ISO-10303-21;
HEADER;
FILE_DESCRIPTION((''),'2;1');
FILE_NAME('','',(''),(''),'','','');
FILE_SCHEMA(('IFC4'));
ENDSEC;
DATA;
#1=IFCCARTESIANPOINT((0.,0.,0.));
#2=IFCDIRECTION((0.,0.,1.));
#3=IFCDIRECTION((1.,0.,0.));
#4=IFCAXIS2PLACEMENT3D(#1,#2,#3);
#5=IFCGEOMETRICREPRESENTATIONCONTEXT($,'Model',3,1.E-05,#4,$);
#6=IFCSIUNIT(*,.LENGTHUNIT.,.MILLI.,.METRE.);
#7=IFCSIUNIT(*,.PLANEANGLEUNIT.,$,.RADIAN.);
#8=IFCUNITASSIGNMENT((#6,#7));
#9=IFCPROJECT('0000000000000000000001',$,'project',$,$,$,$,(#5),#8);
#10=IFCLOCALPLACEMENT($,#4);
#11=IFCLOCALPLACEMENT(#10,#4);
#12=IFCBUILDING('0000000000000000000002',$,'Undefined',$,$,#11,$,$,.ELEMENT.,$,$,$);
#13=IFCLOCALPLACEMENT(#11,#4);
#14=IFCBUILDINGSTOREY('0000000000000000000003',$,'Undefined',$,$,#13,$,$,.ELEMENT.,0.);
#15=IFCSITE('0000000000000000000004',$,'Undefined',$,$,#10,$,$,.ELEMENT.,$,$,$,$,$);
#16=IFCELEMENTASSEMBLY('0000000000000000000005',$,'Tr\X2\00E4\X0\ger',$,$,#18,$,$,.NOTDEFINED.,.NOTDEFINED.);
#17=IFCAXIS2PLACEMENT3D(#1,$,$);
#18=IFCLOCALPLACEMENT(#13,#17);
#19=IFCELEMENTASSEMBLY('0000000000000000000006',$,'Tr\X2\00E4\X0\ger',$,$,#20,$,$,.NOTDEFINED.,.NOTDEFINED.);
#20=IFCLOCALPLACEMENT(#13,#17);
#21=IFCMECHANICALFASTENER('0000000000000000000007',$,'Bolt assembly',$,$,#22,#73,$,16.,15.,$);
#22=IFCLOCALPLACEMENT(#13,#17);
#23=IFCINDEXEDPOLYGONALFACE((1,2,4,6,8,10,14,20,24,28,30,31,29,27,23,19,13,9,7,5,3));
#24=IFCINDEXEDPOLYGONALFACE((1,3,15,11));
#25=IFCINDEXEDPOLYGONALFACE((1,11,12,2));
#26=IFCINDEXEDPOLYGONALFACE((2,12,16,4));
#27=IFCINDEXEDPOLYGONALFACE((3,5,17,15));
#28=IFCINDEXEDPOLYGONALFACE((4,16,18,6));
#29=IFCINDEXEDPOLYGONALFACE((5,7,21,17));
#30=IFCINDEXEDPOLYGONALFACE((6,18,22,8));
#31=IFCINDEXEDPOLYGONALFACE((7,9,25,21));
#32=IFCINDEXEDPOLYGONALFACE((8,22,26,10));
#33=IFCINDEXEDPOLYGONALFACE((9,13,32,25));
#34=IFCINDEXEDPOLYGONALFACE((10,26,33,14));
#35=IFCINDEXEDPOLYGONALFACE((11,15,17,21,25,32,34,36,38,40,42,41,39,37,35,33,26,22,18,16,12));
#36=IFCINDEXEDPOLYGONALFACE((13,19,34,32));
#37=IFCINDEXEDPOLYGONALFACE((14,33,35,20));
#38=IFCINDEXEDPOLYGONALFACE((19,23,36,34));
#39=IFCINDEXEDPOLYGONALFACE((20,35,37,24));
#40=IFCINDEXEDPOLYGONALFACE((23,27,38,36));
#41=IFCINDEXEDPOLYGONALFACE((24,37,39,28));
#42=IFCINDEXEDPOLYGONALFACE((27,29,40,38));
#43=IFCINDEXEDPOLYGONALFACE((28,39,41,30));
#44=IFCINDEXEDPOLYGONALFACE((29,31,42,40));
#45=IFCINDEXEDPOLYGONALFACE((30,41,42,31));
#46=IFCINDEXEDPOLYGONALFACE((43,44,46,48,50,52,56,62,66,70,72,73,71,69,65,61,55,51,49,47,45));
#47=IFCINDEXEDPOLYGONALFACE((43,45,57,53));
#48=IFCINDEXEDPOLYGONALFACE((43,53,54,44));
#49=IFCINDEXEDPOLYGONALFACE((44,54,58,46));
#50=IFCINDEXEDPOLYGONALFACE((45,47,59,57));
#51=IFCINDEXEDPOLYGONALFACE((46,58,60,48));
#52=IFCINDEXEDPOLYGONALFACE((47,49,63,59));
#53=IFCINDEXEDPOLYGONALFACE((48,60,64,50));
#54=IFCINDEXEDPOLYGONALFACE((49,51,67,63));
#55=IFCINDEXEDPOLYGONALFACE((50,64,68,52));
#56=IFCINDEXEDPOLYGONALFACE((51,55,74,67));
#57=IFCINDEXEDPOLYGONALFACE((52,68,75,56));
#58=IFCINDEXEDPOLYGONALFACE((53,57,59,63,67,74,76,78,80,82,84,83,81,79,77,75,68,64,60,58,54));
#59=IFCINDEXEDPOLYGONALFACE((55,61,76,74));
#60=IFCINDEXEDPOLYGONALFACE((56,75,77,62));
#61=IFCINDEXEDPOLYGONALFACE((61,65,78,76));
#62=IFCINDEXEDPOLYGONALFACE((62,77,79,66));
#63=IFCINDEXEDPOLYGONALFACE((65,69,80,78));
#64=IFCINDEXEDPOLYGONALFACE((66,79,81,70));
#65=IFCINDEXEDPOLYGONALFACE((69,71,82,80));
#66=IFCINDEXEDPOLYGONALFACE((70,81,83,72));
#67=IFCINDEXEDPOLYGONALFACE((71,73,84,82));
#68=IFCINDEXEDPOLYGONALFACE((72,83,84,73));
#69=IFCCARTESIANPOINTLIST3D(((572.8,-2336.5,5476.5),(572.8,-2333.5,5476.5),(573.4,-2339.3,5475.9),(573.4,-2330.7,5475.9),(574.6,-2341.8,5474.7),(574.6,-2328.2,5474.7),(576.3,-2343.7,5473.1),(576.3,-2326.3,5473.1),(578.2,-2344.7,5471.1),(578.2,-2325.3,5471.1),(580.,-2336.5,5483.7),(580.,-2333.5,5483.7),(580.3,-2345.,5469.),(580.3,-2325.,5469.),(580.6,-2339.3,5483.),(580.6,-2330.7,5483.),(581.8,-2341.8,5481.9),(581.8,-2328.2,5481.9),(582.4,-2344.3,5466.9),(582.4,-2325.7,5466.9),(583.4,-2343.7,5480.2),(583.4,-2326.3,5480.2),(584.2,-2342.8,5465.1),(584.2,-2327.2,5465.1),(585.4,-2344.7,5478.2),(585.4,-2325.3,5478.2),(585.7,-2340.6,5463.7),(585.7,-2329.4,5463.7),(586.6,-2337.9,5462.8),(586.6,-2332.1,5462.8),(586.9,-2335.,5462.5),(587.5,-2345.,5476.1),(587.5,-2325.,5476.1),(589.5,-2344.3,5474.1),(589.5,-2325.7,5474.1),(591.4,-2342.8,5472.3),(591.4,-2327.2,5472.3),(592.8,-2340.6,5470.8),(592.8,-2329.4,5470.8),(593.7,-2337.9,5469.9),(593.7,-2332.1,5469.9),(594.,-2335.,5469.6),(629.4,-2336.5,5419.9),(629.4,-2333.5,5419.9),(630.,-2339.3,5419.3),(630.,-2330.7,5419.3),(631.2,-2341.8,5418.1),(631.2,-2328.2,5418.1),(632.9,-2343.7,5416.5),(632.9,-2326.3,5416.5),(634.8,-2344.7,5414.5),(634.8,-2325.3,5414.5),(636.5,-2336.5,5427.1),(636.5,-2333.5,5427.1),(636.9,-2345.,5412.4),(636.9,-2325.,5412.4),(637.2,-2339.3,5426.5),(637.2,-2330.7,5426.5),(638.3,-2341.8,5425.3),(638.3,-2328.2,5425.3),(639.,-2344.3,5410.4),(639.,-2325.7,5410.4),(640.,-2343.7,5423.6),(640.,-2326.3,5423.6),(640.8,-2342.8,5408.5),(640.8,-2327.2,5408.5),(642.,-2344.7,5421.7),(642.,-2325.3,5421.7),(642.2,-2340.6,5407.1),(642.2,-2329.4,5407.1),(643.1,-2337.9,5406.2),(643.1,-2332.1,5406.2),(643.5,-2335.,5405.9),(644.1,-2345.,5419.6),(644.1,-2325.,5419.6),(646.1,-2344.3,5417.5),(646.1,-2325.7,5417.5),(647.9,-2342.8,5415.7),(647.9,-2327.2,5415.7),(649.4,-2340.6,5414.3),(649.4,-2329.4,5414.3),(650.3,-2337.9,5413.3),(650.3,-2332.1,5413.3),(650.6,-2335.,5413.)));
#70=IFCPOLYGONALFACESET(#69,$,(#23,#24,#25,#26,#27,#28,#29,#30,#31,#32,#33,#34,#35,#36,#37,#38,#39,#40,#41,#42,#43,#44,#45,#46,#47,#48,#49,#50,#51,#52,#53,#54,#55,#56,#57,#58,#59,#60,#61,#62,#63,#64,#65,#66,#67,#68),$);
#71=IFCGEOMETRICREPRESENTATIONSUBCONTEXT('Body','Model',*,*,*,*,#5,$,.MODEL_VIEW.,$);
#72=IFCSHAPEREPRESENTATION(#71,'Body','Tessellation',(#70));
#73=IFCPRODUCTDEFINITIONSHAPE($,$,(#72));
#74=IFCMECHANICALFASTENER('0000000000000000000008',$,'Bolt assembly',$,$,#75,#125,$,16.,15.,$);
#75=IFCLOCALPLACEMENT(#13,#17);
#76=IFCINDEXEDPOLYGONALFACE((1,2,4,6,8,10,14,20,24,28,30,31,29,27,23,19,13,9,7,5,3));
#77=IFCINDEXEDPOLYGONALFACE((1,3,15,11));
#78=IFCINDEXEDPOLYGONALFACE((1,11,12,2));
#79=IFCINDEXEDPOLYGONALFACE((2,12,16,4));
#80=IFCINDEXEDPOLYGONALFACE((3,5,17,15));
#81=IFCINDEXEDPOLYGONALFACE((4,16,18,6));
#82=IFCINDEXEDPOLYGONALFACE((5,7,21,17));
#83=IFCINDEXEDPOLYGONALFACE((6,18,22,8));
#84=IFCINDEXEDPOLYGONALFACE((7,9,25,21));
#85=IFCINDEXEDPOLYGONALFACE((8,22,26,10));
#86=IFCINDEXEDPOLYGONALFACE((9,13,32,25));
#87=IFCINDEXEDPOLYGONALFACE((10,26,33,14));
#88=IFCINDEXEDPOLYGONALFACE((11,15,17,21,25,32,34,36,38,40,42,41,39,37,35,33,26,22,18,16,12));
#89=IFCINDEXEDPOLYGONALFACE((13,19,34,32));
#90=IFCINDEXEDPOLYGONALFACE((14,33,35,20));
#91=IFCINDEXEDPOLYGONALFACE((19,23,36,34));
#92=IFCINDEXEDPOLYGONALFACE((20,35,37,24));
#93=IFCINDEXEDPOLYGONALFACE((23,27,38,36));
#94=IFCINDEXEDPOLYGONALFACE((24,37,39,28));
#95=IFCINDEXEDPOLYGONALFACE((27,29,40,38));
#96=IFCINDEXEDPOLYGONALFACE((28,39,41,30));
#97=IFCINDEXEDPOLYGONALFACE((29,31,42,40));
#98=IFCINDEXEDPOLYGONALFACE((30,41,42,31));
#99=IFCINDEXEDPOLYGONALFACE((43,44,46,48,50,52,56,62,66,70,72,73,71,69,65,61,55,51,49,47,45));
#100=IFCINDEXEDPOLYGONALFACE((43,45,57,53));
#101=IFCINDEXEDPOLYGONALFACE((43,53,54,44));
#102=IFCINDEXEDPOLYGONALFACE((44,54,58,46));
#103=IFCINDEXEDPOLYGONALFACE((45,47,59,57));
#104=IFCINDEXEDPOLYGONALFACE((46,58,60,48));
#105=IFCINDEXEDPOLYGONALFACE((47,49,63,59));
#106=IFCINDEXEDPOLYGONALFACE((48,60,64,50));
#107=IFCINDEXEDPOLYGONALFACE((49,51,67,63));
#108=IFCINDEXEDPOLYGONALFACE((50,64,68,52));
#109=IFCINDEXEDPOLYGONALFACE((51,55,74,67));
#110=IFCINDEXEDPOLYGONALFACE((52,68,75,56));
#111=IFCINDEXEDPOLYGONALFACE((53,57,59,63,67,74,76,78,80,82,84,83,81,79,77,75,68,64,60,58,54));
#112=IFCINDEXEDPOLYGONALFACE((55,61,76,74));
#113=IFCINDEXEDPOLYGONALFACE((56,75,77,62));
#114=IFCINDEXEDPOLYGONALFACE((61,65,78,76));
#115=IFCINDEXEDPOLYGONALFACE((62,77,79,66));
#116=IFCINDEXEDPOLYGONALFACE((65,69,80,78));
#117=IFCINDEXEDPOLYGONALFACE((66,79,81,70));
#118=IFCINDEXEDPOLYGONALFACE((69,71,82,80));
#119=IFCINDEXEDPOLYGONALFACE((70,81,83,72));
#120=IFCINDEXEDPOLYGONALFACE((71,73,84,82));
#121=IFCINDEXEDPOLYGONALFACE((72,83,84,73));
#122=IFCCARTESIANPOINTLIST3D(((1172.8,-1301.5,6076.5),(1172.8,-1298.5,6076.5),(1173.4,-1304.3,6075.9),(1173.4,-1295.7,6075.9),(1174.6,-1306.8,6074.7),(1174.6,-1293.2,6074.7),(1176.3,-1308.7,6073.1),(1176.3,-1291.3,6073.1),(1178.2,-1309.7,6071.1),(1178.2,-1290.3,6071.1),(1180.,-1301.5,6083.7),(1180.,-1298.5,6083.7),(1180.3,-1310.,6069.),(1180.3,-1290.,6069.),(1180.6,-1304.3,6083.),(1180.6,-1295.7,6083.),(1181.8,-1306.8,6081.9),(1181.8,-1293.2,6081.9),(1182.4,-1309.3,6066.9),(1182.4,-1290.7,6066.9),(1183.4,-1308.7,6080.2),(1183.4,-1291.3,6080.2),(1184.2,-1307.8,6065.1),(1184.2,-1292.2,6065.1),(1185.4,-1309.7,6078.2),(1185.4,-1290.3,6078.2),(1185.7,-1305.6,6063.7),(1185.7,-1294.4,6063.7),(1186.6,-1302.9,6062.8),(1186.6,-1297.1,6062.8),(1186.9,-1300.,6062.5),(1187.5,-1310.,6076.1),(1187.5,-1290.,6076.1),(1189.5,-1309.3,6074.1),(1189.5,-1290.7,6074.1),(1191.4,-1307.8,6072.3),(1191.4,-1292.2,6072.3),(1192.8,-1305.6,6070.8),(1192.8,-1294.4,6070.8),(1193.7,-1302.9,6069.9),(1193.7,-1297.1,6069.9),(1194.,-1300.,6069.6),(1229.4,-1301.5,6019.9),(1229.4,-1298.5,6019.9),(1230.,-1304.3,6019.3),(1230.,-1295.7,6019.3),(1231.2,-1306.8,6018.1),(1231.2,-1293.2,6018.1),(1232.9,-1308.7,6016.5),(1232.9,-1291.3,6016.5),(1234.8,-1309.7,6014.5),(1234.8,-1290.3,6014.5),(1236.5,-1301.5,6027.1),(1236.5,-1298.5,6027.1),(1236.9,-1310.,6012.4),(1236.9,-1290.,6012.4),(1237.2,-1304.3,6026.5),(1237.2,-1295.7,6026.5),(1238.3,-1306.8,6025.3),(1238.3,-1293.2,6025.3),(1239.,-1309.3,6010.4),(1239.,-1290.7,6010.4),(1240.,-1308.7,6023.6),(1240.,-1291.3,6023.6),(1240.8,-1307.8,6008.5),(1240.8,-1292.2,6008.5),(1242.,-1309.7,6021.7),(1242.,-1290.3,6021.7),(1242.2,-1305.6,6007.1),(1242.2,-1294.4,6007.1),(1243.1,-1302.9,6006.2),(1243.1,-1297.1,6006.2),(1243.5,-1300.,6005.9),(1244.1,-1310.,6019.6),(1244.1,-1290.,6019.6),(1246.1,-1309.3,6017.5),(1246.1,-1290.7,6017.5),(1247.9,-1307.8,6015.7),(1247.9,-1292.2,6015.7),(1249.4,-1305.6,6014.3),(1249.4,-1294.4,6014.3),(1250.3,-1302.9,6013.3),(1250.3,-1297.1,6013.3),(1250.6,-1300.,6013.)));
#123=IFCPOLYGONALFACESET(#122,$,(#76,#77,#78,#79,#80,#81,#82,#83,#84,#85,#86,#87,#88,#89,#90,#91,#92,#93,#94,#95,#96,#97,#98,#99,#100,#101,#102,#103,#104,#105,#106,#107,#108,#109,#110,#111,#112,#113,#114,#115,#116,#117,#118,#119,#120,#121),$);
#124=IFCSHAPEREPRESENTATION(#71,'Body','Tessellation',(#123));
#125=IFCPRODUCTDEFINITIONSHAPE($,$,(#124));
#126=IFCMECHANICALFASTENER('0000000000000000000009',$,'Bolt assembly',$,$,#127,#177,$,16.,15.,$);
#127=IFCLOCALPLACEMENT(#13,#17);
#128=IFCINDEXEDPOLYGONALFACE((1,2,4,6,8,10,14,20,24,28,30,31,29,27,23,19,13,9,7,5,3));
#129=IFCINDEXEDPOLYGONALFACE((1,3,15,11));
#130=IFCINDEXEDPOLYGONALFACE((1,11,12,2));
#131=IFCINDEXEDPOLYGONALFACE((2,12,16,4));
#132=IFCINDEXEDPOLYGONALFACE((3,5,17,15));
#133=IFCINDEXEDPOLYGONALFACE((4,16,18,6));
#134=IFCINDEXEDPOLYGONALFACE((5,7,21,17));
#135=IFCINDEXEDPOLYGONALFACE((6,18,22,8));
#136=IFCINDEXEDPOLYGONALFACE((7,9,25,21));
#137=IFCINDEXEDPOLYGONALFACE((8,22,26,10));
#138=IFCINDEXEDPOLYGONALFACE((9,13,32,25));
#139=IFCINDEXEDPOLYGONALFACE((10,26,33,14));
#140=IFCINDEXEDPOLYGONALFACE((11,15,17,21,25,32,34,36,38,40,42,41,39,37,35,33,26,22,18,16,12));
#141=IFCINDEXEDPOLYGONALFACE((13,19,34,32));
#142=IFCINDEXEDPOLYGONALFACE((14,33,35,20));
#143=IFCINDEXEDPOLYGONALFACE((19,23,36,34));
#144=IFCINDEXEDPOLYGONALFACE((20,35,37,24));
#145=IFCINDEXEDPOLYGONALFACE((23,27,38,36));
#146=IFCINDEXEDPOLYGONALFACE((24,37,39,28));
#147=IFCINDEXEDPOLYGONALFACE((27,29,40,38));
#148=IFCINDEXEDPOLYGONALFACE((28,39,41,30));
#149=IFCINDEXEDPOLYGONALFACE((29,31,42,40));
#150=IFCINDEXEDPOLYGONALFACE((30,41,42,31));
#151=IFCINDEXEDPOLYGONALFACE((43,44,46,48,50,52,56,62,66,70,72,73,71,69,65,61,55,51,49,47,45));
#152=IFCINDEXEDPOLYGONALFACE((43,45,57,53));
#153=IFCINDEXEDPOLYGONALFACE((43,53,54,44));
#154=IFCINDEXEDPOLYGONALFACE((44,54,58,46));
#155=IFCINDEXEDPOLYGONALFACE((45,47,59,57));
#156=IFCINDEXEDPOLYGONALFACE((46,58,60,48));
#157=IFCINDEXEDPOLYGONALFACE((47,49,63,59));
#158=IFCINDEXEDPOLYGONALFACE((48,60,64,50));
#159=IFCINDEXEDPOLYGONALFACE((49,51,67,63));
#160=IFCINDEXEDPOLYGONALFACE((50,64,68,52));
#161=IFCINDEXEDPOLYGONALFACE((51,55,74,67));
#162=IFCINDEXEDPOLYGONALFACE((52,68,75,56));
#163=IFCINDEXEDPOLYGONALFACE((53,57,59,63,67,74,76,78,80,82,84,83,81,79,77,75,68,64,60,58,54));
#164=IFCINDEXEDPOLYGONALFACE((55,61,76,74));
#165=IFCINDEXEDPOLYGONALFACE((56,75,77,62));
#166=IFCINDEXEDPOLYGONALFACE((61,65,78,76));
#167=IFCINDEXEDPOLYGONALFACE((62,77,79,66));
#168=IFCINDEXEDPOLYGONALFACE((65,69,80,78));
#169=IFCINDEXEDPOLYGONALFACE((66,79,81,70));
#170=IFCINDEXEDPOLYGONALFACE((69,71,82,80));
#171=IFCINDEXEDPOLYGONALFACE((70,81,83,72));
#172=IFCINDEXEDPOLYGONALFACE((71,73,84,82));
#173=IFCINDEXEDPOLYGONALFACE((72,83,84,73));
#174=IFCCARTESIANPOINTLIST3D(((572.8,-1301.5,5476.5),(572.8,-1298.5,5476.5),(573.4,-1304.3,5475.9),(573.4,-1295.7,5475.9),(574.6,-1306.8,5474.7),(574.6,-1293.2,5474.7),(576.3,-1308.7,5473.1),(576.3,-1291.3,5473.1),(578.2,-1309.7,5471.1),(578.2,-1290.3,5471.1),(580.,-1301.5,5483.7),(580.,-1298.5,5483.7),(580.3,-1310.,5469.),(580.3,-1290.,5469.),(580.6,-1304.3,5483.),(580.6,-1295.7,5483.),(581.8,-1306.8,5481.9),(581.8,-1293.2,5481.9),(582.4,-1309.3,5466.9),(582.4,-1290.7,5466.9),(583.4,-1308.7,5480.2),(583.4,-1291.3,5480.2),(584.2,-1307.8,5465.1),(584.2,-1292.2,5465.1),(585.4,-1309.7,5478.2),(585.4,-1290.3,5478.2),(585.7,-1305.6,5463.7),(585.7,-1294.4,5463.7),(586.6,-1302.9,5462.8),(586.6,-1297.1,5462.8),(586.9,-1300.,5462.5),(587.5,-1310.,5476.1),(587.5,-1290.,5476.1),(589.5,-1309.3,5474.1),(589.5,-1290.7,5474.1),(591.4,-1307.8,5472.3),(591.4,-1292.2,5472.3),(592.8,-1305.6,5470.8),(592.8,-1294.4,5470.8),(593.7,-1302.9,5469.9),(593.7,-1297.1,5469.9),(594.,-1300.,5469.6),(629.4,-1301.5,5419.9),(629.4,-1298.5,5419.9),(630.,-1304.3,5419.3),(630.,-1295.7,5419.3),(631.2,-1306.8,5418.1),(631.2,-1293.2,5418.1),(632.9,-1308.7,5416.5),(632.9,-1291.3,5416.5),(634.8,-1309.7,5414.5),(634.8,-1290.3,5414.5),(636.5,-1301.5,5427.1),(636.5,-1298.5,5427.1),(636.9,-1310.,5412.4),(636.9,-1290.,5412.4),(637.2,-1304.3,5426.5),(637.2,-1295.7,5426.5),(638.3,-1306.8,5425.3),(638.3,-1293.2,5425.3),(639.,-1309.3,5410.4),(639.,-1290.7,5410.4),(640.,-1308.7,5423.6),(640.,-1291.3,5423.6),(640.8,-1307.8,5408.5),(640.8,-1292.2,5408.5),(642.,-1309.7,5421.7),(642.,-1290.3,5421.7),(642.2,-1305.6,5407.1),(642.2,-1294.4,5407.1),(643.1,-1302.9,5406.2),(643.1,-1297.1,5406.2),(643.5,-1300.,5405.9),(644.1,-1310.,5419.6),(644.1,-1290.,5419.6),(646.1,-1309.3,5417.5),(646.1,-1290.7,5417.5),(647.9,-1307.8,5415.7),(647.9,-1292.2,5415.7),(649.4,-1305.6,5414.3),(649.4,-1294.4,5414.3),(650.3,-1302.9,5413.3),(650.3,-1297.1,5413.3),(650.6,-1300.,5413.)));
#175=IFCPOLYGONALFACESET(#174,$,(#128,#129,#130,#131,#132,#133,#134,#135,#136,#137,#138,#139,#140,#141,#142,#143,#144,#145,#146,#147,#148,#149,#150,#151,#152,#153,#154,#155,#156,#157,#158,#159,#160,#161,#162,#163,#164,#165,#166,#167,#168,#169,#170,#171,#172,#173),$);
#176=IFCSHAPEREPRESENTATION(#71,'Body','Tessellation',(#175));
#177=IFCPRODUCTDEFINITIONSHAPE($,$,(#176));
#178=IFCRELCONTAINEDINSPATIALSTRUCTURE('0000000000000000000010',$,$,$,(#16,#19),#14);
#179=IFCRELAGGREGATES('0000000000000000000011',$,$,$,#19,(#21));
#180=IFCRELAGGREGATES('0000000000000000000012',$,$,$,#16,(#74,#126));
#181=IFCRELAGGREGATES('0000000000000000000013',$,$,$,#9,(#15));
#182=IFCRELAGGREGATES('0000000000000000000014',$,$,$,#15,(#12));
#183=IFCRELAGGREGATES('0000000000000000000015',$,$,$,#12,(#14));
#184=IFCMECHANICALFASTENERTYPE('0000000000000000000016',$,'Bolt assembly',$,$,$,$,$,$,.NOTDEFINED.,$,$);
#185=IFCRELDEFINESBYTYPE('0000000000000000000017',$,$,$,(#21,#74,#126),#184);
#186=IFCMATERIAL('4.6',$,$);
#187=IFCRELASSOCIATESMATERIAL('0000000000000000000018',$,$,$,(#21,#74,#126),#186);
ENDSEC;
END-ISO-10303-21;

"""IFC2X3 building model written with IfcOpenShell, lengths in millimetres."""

from ifc_helpers import new_model, si_unit, frame, origin_with_axes, origin_2d_with_axis, place, context, subcontext, project, spatial, circle, extrude, source, transform, mapped, material, type_object, element, aggregate, save


model = new_model("IFC2X3")

# Units and contexts
model_context = context("Model", 3, precision=1e-05, world=origin_with_axes())
body_context = subcontext(model_context, "Body", "Model", "MODEL_VIEW")
ifc_project = project(units=[si_unit("LENGTHUNIT", "METRE", prefix="MILLI"), si_unit("PLANEANGLEUNIT", "RADIAN")], contexts=[model_context])

# Site, building, storey
site_placement = place(None, origin_with_axes())
site = spatial("IfcSite", under=ifc_project, at=site_placement, Name="Undefined", CompositionType="ELEMENT")
building_placement = place(site_placement, origin_with_axes())
building = spatial("IfcBuilding", under=site, at=building_placement, Name="Undefined", CompositionType="ELEMENT")
storey_placement = place(building_placement, origin_with_axes())
storey = spatial("IfcBuildingStorey", under=building, at=storey_placement, Name="Undefined", CompositionType="ELEMENT", Elevation=0.0)

# Element assemblies
assembly_1_placement = place(storey_placement, origin_with_axes())
assembly_1 = element("IfcElementAssembly", 1, at=assembly_1_placement, inside=storey, Name="Träger", AssemblyPlace="NOTDEFINED", PredefinedType="NOTDEFINED")
assembly_2_placement = place(storey_placement, origin_with_axes())
assembly_2 = element("IfcElementAssembly", 2, at=assembly_2_placement, inside=storey, Name="Träger", AssemblyPlace="NOTDEFINED", PredefinedType="NOTDEFINED")

# Mechanical fasteners
ifc_material_1 = material(Name="4.6")
mechanical_fastener_type = type_object("IfcMechanicalFastenerType", Name="Bolt assembly")
shared_shape_1 = source(origin_with_axes(), body_context, "Body", "SweptSolid", [
    extrude(circle(Radius=10.0, at=origin_2d_with_axis()), frame((0.0, 0.0, 0.0), z_axis=(0.0, 1.0, 0.0), x_axis=(1.0, 0.0, 0.0)), (0.0, 0.0, 1.0), 10.1),
])
mechanical_fastener_1_placement = place(assembly_2_placement, frame((587.0, -2335.0, 5476.7), z_axis=(0.0, 1.0, 0.0), x_axis=(0.707107, 0.0, -0.707107)))
mechanical_fastener_1 = element("IfcMechanicalFastener", 3, at=mechanical_fastener_1_placement, type_object=mechanical_fastener_type, material=ifc_material_1, Name="Bolt assembly", NominalDiameter=16.0, NominalLength=15.0, context=body_context, shape_type="MappedRepresentation", body=[
    mapped(shared_shape_1, transform((0.0, 0.0, 0.0))),
    mapped(shared_shape_1, transform((80.0, 0.0, 0.0))),
])
aggregate(assembly_2, [mechanical_fastener_1])
mechanical_fastener_2_placement = place(assembly_1_placement, frame((1187.0, -1300.0, 6076.7), z_axis=(0.0, 1.0, 0.0), x_axis=(0.707107, 0.0, -0.707107)))
mechanical_fastener_2 = element("IfcMechanicalFastener", 4, at=mechanical_fastener_2_placement, type_object=mechanical_fastener_type, material=ifc_material_1, Name="Bolt assembly", NominalDiameter=16.0, NominalLength=15.0, context=body_context, shape_type="MappedRepresentation", body=[
    mapped(shared_shape_1, transform((0.0, 0.0, 0.0))),
    mapped(shared_shape_1, transform((80.0, 0.0, 0.0))),
])
mechanical_fastener_3_placement = place(assembly_1_placement, frame((587.0, -1300.0, 5476.7), z_axis=(0.0, 1.0, 0.0), x_axis=(0.707107, 0.0, -0.707107)))
mechanical_fastener_3 = element("IfcMechanicalFastener", 5, at=mechanical_fastener_3_placement, type_object=mechanical_fastener_type, material=ifc_material_1, Name="Bolt assembly", NominalDiameter=16.0, NominalLength=15.0, context=body_context, shape_type="MappedRepresentation", body=[
    mapped(shared_shape_1, transform((0.0, 0.0, 0.0))),
    mapped(shared_shape_1, transform((80.0, 0.0, 0.0))),
])
aggregate(assembly_1, [mechanical_fastener_2, mechanical_fastener_3])

save(model, "model.ifc")
